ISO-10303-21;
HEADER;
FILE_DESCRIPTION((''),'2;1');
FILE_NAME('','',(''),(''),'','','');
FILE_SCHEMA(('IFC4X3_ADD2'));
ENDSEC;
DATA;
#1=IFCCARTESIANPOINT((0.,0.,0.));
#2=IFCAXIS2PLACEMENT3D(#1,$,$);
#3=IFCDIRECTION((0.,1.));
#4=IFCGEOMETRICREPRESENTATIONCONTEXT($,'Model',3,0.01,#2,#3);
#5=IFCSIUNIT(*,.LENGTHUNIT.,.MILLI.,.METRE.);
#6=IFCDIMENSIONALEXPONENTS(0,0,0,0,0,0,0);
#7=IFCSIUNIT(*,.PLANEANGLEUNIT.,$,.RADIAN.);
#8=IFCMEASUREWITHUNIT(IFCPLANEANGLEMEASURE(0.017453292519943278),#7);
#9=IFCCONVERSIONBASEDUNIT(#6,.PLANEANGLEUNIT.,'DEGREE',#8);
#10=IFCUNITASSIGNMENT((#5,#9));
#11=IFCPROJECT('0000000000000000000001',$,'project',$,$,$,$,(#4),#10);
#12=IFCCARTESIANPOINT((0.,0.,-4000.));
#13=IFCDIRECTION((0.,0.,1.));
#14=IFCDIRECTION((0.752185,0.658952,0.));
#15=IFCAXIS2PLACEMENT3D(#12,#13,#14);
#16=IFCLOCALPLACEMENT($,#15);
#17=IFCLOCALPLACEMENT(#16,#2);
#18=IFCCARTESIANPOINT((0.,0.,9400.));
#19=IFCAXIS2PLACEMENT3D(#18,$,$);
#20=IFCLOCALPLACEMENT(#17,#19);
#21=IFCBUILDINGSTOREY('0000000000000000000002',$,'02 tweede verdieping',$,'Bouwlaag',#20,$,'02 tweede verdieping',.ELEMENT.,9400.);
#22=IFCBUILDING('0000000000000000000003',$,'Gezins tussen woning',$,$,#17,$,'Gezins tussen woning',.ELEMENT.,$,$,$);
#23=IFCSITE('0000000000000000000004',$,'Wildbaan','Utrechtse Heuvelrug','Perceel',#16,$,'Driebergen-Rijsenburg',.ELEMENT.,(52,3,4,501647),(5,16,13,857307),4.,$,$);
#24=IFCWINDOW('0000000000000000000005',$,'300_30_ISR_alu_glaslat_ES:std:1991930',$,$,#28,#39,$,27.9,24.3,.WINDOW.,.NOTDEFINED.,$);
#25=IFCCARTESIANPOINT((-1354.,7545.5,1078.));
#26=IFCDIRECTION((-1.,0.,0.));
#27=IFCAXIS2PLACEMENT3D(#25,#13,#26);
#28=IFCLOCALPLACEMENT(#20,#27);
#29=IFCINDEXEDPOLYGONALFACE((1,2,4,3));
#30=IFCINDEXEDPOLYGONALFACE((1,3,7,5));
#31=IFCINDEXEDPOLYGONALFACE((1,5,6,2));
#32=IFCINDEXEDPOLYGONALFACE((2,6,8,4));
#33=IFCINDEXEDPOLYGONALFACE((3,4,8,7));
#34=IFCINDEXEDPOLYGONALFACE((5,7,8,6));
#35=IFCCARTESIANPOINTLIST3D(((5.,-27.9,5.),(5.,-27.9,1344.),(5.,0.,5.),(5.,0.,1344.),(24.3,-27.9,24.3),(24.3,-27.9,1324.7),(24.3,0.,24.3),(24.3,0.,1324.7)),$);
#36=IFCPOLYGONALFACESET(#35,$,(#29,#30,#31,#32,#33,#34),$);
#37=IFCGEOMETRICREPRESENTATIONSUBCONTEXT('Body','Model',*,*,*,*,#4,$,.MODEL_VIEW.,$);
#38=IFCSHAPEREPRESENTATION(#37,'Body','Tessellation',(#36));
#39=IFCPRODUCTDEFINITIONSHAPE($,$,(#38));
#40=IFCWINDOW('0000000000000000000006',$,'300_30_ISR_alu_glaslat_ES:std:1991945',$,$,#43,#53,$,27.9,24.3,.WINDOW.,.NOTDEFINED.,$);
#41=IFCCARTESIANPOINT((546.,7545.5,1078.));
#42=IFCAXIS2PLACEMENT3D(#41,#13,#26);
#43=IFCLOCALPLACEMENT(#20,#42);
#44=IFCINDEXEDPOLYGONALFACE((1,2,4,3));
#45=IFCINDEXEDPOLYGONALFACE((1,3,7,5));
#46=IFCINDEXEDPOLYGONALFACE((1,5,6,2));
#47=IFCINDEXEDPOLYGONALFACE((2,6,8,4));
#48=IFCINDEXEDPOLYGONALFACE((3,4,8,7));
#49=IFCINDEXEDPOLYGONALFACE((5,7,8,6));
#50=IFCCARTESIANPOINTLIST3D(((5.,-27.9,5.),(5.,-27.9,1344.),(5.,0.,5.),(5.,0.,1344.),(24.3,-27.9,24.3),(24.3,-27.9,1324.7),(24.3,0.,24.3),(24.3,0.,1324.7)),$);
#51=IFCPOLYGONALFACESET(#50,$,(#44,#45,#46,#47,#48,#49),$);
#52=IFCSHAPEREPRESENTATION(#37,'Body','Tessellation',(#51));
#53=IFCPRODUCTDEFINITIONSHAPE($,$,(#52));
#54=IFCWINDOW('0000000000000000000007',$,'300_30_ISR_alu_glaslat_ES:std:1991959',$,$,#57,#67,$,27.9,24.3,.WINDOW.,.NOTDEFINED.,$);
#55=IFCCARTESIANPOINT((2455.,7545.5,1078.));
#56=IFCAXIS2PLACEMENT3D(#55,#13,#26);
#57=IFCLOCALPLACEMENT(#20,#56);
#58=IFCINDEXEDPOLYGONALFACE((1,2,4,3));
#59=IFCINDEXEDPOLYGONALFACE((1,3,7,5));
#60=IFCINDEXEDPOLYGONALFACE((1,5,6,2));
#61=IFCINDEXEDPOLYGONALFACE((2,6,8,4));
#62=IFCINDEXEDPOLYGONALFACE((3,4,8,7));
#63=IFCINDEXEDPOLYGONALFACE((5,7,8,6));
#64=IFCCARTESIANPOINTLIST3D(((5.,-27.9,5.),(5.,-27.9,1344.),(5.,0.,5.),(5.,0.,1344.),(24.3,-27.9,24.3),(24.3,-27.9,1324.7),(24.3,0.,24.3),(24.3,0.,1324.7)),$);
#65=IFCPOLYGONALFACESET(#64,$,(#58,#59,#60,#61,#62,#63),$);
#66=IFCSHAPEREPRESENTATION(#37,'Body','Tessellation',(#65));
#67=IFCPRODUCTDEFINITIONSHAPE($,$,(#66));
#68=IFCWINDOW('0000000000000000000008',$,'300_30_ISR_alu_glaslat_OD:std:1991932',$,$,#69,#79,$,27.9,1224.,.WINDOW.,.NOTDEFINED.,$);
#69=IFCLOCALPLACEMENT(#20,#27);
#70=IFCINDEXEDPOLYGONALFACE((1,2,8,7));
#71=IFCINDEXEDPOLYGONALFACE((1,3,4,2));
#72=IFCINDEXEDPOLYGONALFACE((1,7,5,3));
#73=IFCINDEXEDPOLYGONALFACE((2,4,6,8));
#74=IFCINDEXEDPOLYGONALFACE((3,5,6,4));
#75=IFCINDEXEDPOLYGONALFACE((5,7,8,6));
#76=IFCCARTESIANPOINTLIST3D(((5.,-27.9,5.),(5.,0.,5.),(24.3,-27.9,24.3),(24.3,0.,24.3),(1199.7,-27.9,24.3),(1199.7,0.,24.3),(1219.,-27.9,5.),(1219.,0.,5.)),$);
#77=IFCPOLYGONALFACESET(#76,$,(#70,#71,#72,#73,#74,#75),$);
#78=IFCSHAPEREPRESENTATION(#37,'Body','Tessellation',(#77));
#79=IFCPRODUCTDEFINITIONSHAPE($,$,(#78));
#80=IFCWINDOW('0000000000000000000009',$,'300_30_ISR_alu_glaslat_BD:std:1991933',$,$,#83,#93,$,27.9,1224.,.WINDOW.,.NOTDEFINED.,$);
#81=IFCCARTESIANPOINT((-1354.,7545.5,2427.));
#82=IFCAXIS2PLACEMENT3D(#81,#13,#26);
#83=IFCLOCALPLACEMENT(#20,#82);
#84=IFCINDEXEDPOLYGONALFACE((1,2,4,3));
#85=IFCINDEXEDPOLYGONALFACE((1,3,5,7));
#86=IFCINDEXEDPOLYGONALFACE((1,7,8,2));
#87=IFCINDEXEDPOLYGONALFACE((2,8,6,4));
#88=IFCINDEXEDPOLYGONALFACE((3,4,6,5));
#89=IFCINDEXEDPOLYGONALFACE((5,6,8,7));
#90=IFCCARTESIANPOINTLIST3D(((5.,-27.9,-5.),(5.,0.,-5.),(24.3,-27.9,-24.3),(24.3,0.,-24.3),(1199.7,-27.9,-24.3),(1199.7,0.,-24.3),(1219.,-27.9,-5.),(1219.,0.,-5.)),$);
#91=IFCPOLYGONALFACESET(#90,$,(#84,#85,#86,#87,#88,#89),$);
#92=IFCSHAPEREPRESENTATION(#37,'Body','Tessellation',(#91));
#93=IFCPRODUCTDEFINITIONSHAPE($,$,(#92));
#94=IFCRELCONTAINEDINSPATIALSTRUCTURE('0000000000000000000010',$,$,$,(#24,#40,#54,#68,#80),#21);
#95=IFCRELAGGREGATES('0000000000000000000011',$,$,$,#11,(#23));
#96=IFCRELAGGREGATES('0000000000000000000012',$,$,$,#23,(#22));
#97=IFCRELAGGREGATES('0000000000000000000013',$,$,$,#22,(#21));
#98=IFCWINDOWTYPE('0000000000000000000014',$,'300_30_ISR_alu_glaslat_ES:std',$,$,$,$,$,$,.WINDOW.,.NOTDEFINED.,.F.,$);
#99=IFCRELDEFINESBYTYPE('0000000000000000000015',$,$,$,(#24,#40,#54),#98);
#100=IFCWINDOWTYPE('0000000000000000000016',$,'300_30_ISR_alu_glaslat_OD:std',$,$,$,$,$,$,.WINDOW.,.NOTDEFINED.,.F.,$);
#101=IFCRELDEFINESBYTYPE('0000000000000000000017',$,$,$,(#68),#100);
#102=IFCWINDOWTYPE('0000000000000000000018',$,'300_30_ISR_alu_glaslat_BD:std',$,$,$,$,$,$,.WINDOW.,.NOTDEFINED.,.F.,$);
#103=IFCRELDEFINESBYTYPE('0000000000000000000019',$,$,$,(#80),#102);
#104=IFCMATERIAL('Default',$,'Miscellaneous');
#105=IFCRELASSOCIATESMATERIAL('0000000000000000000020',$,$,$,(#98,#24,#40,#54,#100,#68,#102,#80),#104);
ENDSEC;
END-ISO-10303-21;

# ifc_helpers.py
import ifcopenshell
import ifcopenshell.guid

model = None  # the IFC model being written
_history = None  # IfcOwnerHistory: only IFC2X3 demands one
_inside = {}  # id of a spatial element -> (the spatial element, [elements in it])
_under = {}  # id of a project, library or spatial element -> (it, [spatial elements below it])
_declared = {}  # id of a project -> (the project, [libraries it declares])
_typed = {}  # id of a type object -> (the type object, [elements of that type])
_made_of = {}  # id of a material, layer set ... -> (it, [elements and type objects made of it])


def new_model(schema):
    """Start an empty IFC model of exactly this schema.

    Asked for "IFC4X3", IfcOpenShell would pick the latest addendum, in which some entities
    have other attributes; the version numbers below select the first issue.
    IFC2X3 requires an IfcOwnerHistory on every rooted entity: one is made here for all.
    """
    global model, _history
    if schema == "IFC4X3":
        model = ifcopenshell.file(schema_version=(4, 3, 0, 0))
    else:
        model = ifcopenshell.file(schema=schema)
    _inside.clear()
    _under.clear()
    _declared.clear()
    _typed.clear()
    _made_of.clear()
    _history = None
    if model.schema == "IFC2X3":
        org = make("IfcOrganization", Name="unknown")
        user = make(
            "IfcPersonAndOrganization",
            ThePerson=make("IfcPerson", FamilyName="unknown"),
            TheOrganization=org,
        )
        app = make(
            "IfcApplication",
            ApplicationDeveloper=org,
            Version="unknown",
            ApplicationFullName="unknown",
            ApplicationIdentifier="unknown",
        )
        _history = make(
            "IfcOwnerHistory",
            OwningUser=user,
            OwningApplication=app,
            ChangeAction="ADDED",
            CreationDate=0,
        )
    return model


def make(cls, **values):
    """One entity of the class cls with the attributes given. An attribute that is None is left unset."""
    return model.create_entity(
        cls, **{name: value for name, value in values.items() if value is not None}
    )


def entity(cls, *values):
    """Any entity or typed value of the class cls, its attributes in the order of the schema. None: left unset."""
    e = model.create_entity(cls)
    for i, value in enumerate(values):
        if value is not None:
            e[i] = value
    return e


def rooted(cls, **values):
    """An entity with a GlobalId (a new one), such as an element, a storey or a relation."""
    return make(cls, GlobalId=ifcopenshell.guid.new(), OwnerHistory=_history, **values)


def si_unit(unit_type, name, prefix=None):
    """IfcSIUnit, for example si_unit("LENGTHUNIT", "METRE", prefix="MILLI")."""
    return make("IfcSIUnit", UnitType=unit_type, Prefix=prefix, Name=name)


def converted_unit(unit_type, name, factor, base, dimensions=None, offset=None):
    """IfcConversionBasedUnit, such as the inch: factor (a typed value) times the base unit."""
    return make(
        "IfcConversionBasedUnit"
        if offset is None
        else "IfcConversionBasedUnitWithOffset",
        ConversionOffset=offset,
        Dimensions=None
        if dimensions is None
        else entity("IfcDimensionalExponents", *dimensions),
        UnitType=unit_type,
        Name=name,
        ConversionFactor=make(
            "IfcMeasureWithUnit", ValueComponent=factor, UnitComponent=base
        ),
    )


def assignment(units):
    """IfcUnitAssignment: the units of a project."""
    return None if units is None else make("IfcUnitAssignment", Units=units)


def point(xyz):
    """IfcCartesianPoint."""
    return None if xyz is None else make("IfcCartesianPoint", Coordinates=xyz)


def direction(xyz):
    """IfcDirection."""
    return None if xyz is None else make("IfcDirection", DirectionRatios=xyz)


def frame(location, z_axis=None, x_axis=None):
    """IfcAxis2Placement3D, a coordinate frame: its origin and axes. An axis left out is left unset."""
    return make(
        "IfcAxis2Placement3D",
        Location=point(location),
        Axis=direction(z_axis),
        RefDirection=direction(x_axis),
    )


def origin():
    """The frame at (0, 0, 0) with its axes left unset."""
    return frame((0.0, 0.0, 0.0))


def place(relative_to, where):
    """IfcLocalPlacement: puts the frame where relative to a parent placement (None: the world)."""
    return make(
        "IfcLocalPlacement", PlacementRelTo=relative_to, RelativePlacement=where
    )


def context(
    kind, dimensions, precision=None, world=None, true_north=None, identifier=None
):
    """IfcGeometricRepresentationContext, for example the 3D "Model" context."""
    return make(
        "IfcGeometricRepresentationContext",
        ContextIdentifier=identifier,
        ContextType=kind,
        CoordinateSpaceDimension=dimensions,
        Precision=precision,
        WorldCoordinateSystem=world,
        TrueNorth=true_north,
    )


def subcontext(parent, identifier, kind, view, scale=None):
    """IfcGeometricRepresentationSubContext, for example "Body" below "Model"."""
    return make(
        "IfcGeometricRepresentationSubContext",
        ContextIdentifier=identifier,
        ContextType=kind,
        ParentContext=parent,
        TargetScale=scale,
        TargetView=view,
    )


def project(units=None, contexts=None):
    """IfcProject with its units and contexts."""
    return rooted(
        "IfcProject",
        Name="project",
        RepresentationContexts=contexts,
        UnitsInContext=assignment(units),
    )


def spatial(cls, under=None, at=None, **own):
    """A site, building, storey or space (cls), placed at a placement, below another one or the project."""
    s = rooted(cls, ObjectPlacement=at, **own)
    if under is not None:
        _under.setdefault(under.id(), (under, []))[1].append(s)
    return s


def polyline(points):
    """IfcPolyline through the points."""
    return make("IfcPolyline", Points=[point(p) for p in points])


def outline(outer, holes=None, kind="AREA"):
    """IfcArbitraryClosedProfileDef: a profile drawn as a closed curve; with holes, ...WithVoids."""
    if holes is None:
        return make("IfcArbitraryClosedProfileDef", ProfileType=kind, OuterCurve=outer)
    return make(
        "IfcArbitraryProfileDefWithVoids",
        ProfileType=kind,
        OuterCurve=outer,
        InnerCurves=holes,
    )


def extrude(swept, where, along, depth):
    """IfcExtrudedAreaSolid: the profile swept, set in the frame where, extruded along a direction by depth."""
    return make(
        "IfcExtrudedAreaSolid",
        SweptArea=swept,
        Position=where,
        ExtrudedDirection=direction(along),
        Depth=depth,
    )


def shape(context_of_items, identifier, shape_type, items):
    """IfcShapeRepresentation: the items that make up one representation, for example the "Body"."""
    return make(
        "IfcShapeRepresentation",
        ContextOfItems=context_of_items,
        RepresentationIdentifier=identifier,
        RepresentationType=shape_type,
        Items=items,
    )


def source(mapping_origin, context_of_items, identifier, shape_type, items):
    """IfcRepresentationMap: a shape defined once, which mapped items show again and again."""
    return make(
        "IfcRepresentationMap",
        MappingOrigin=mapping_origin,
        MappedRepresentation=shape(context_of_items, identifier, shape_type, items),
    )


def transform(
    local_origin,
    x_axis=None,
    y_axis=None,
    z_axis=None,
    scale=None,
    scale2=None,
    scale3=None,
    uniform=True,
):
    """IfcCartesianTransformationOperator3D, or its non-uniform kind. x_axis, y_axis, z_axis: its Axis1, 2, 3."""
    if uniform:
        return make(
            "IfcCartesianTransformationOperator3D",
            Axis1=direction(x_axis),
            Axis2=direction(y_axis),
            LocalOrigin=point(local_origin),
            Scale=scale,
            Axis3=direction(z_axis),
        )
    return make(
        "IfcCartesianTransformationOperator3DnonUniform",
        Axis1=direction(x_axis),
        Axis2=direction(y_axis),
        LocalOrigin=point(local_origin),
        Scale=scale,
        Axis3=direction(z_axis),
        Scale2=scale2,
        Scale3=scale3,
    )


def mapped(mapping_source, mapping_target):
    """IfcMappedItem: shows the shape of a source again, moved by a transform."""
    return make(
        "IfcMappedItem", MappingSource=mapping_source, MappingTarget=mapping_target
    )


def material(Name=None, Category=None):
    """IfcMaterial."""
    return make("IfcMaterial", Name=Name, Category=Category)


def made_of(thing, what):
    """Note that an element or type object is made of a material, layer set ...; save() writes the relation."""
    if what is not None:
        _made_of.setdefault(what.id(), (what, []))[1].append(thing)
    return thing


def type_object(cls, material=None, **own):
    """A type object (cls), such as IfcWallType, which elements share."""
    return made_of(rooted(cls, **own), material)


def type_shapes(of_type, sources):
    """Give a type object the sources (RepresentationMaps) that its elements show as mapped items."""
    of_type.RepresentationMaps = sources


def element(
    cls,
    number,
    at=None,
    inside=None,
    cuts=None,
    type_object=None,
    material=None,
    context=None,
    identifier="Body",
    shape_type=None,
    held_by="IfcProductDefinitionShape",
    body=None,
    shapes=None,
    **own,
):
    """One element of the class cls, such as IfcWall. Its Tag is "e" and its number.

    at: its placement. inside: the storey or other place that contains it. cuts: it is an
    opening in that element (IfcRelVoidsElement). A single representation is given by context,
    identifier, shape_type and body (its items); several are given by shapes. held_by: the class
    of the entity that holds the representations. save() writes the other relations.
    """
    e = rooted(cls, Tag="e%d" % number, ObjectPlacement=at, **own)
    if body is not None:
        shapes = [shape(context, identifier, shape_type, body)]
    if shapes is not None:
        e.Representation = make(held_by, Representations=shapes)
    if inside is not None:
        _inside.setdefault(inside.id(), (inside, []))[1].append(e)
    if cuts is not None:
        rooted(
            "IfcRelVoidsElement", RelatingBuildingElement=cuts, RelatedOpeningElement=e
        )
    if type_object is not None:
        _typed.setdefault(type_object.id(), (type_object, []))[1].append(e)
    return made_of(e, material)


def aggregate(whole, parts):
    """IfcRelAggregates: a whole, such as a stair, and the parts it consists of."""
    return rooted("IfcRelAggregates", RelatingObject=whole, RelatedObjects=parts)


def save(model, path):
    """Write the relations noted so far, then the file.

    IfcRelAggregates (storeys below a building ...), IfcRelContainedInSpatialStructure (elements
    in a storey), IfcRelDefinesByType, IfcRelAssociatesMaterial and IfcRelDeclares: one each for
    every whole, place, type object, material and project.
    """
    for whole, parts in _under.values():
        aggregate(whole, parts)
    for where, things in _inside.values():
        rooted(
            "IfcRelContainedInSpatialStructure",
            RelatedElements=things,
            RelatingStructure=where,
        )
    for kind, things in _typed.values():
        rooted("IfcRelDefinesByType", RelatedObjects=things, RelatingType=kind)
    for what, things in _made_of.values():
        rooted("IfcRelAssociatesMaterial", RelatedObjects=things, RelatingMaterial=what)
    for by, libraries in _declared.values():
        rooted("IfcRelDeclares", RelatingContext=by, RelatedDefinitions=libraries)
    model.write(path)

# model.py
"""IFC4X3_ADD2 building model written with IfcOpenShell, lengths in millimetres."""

from ifc_helpers import new_model, entity, si_unit, converted_unit, direction, frame, origin, place, context, subcontext, project, spatial, polyline, outline, extrude, source, transform, mapped, material, type_object, type_shapes, element, save


model = new_model("IFC4X3_ADD2")

# Units and contexts
model_context = context("Model", 3, precision=0.01, world=origin(), true_north=direction((0.0, 1.0)))
body_context = subcontext(model_context, "Body", "Model", "MODEL_VIEW")
ifc_project = project(units=[si_unit("LENGTHUNIT", "METRE", prefix="MILLI"), converted_unit("PLANEANGLEUNIT", "DEGREE", entity("IfcPlaneAngleMeasure", 0.017453292519943278), si_unit("PLANEANGLEUNIT", "RADIAN"), dimensions=[0, 0, 0, 0, 0, 0, 0])], contexts=[model_context])

# Site, building, storey
site_placement = place(None, frame((0.0, 0.0, -4000.0), z_axis=(0.0, 0.0, 1.0), x_axis=(0.752185, 0.658952, 0.0)))
site = spatial("IfcSite", under=ifc_project, at=site_placement, Name="Wildbaan", Description="Utrechtse Heuvelrug", ObjectType="Perceel", LongName="Driebergen-Rijsenburg", CompositionType="ELEMENT", RefLatitude=(52, 3, 4, 501647), RefLongitude=(5, 16, 13, 857307), RefElevation=4.0)
building_placement = place(site_placement, origin())
building = spatial("IfcBuilding", under=site, at=building_placement, Name="Gezins tussen woning", LongName="Gezins tussen woning", CompositionType="ELEMENT")
storey_placement = place(building_placement, frame((0.0, 0.0, 9400.0)))
storey = spatial("IfcBuildingStorey", under=building, at=storey_placement, Name="02 tweede verdieping", ObjectType="Bouwlaag", LongName="02 tweede verdieping", CompositionType="ELEMENT", Elevation=9400.0)

# Windows
ifc_material_1 = material(Name="Default", Category="Miscellaneous")
window_type_1 = type_object("IfcWindowType", Name="300_30_ISR_alu_glaslat_ES:std", ParameterTakesPrecedence=False, PartitioningType="NOTDEFINED", PredefinedType="WINDOW", material=ifc_material_1)
shared_shape_1 = source(origin(), body_context, "Body", "SweptSolid", [
    extrude(outline(polyline([(-650.2, -9.6), (650.2, -9.6), (669.5, 9.6), (-669.5, 9.6), (-650.2, -9.6)])), frame((14.6, -27.9, 674.5), z_axis=(0.0, 1.0, 0.0), x_axis=(0.0, 0.0, -1.0)), (0.0, 0.0, 1.0), 27.9),
])
type_shapes(window_type_1, [shared_shape_1])
for number, where, z_axis, x_axis, name in (
    (1, (-1354.0, 7545.5, 1078.0), (0.0, 0.0, 1.0), (-1.0, 0.0, 0.0), "300_30_ISR_alu_glaslat_ES:std:1991930"),
    (2, (546.0, 7545.5, 1078.0), (0.0, 0.0, 1.0), (-1.0, 0.0, 0.0), "300_30_ISR_alu_glaslat_ES:std:1991945"),
    (3, (2455.0, 7545.5, 1078.0), (0.0, 0.0, 1.0), (-1.0, 0.0, 0.0), "300_30_ISR_alu_glaslat_ES:std:1991959"),
):
    element("IfcWindow", number, at=place(storey_placement, frame(where, z_axis=z_axis, x_axis=x_axis)), inside=storey, type_object=window_type_1, material=ifc_material_1, Name=name, OverallHeight=27.9, OverallWidth=24.3, PartitioningType="NOTDEFINED", PredefinedType="WINDOW", context=body_context, shape_type="MappedRepresentation", body=[
        mapped(shared_shape_1, transform((0.0, 0.0, 0.0), scale=1.0)),
    ])
window_type_2 = type_object("IfcWindowType", Name="300_30_ISR_alu_glaslat_OD:std", ParameterTakesPrecedence=False, PartitioningType="NOTDEFINED", PredefinedType="WINDOW", material=ifc_material_1)
shared_shape_2 = source(origin(), body_context, "Body", "SweptSolid", [
    extrude(outline(polyline([(-587.7, -9.7), (587.7, -9.7), (607.0, 9.7), (-607.0, 9.6), (-587.7, -9.7)])), frame((612.0, -27.9, 14.6), z_axis=(0.0, 1.0, 0.0), x_axis=(1.0, 0.0, 0.0)), (0.0, 0.0, 1.0), 27.9),
])
type_shapes(window_type_2, [shared_shape_2])
window_1_placement = place(storey_placement, frame((-1354.0, 7545.5, 1078.0), z_axis=(0.0, 0.0, 1.0), x_axis=(-1.0, 0.0, 0.0)))
element("IfcWindow", 4, at=window_1_placement, inside=storey, type_object=window_type_2, material=ifc_material_1, Name="300_30_ISR_alu_glaslat_OD:std:1991932", OverallHeight=27.9, OverallWidth=1224.0, PartitioningType="NOTDEFINED", PredefinedType="WINDOW", context=body_context, shape_type="MappedRepresentation", body=[
    mapped(shared_shape_2, transform((0.0, 0.0, 0.0), scale=1.0)),
])
window_type_3 = type_object("IfcWindowType", Name="300_30_ISR_alu_glaslat_BD:std", ParameterTakesPrecedence=False, PartitioningType="NOTDEFINED", PredefinedType="WINDOW", material=ifc_material_1)
shared_shape_3 = source(origin(), body_context, "Body", "SweptSolid", [
    extrude(outline(polyline([(-607.0, -9.6), (607.0, -9.6), (587.7, 9.6), (-587.7, 9.7), (-607.0, -9.6)])), frame((612.0, -27.9, -14.6), z_axis=(0.0, 1.0, 0.0), x_axis=(1.0, 0.0, 0.0)), (0.0, 0.0, 1.0), 27.9),
])
type_shapes(window_type_3, [shared_shape_3])
window_2_placement = place(storey_placement, frame((-1354.0, 7545.5, 2427.0), z_axis=(0.0, 0.0, 1.0), x_axis=(-1.0, 0.0, 0.0)))
element("IfcWindow", 5, at=window_2_placement, inside=storey, type_object=window_type_3, material=ifc_material_1, Name="300_30_ISR_alu_glaslat_BD:std:1991933", OverallHeight=27.9, OverallWidth=1224.0, PartitioningType="NOTDEFINED", PredefinedType="WINDOW", context=body_context, shape_type="MappedRepresentation", body=[
    mapped(shared_shape_3, transform((0.0, 0.0, 0.0), scale=1.0)),
])

save(model, "model.ifc")
